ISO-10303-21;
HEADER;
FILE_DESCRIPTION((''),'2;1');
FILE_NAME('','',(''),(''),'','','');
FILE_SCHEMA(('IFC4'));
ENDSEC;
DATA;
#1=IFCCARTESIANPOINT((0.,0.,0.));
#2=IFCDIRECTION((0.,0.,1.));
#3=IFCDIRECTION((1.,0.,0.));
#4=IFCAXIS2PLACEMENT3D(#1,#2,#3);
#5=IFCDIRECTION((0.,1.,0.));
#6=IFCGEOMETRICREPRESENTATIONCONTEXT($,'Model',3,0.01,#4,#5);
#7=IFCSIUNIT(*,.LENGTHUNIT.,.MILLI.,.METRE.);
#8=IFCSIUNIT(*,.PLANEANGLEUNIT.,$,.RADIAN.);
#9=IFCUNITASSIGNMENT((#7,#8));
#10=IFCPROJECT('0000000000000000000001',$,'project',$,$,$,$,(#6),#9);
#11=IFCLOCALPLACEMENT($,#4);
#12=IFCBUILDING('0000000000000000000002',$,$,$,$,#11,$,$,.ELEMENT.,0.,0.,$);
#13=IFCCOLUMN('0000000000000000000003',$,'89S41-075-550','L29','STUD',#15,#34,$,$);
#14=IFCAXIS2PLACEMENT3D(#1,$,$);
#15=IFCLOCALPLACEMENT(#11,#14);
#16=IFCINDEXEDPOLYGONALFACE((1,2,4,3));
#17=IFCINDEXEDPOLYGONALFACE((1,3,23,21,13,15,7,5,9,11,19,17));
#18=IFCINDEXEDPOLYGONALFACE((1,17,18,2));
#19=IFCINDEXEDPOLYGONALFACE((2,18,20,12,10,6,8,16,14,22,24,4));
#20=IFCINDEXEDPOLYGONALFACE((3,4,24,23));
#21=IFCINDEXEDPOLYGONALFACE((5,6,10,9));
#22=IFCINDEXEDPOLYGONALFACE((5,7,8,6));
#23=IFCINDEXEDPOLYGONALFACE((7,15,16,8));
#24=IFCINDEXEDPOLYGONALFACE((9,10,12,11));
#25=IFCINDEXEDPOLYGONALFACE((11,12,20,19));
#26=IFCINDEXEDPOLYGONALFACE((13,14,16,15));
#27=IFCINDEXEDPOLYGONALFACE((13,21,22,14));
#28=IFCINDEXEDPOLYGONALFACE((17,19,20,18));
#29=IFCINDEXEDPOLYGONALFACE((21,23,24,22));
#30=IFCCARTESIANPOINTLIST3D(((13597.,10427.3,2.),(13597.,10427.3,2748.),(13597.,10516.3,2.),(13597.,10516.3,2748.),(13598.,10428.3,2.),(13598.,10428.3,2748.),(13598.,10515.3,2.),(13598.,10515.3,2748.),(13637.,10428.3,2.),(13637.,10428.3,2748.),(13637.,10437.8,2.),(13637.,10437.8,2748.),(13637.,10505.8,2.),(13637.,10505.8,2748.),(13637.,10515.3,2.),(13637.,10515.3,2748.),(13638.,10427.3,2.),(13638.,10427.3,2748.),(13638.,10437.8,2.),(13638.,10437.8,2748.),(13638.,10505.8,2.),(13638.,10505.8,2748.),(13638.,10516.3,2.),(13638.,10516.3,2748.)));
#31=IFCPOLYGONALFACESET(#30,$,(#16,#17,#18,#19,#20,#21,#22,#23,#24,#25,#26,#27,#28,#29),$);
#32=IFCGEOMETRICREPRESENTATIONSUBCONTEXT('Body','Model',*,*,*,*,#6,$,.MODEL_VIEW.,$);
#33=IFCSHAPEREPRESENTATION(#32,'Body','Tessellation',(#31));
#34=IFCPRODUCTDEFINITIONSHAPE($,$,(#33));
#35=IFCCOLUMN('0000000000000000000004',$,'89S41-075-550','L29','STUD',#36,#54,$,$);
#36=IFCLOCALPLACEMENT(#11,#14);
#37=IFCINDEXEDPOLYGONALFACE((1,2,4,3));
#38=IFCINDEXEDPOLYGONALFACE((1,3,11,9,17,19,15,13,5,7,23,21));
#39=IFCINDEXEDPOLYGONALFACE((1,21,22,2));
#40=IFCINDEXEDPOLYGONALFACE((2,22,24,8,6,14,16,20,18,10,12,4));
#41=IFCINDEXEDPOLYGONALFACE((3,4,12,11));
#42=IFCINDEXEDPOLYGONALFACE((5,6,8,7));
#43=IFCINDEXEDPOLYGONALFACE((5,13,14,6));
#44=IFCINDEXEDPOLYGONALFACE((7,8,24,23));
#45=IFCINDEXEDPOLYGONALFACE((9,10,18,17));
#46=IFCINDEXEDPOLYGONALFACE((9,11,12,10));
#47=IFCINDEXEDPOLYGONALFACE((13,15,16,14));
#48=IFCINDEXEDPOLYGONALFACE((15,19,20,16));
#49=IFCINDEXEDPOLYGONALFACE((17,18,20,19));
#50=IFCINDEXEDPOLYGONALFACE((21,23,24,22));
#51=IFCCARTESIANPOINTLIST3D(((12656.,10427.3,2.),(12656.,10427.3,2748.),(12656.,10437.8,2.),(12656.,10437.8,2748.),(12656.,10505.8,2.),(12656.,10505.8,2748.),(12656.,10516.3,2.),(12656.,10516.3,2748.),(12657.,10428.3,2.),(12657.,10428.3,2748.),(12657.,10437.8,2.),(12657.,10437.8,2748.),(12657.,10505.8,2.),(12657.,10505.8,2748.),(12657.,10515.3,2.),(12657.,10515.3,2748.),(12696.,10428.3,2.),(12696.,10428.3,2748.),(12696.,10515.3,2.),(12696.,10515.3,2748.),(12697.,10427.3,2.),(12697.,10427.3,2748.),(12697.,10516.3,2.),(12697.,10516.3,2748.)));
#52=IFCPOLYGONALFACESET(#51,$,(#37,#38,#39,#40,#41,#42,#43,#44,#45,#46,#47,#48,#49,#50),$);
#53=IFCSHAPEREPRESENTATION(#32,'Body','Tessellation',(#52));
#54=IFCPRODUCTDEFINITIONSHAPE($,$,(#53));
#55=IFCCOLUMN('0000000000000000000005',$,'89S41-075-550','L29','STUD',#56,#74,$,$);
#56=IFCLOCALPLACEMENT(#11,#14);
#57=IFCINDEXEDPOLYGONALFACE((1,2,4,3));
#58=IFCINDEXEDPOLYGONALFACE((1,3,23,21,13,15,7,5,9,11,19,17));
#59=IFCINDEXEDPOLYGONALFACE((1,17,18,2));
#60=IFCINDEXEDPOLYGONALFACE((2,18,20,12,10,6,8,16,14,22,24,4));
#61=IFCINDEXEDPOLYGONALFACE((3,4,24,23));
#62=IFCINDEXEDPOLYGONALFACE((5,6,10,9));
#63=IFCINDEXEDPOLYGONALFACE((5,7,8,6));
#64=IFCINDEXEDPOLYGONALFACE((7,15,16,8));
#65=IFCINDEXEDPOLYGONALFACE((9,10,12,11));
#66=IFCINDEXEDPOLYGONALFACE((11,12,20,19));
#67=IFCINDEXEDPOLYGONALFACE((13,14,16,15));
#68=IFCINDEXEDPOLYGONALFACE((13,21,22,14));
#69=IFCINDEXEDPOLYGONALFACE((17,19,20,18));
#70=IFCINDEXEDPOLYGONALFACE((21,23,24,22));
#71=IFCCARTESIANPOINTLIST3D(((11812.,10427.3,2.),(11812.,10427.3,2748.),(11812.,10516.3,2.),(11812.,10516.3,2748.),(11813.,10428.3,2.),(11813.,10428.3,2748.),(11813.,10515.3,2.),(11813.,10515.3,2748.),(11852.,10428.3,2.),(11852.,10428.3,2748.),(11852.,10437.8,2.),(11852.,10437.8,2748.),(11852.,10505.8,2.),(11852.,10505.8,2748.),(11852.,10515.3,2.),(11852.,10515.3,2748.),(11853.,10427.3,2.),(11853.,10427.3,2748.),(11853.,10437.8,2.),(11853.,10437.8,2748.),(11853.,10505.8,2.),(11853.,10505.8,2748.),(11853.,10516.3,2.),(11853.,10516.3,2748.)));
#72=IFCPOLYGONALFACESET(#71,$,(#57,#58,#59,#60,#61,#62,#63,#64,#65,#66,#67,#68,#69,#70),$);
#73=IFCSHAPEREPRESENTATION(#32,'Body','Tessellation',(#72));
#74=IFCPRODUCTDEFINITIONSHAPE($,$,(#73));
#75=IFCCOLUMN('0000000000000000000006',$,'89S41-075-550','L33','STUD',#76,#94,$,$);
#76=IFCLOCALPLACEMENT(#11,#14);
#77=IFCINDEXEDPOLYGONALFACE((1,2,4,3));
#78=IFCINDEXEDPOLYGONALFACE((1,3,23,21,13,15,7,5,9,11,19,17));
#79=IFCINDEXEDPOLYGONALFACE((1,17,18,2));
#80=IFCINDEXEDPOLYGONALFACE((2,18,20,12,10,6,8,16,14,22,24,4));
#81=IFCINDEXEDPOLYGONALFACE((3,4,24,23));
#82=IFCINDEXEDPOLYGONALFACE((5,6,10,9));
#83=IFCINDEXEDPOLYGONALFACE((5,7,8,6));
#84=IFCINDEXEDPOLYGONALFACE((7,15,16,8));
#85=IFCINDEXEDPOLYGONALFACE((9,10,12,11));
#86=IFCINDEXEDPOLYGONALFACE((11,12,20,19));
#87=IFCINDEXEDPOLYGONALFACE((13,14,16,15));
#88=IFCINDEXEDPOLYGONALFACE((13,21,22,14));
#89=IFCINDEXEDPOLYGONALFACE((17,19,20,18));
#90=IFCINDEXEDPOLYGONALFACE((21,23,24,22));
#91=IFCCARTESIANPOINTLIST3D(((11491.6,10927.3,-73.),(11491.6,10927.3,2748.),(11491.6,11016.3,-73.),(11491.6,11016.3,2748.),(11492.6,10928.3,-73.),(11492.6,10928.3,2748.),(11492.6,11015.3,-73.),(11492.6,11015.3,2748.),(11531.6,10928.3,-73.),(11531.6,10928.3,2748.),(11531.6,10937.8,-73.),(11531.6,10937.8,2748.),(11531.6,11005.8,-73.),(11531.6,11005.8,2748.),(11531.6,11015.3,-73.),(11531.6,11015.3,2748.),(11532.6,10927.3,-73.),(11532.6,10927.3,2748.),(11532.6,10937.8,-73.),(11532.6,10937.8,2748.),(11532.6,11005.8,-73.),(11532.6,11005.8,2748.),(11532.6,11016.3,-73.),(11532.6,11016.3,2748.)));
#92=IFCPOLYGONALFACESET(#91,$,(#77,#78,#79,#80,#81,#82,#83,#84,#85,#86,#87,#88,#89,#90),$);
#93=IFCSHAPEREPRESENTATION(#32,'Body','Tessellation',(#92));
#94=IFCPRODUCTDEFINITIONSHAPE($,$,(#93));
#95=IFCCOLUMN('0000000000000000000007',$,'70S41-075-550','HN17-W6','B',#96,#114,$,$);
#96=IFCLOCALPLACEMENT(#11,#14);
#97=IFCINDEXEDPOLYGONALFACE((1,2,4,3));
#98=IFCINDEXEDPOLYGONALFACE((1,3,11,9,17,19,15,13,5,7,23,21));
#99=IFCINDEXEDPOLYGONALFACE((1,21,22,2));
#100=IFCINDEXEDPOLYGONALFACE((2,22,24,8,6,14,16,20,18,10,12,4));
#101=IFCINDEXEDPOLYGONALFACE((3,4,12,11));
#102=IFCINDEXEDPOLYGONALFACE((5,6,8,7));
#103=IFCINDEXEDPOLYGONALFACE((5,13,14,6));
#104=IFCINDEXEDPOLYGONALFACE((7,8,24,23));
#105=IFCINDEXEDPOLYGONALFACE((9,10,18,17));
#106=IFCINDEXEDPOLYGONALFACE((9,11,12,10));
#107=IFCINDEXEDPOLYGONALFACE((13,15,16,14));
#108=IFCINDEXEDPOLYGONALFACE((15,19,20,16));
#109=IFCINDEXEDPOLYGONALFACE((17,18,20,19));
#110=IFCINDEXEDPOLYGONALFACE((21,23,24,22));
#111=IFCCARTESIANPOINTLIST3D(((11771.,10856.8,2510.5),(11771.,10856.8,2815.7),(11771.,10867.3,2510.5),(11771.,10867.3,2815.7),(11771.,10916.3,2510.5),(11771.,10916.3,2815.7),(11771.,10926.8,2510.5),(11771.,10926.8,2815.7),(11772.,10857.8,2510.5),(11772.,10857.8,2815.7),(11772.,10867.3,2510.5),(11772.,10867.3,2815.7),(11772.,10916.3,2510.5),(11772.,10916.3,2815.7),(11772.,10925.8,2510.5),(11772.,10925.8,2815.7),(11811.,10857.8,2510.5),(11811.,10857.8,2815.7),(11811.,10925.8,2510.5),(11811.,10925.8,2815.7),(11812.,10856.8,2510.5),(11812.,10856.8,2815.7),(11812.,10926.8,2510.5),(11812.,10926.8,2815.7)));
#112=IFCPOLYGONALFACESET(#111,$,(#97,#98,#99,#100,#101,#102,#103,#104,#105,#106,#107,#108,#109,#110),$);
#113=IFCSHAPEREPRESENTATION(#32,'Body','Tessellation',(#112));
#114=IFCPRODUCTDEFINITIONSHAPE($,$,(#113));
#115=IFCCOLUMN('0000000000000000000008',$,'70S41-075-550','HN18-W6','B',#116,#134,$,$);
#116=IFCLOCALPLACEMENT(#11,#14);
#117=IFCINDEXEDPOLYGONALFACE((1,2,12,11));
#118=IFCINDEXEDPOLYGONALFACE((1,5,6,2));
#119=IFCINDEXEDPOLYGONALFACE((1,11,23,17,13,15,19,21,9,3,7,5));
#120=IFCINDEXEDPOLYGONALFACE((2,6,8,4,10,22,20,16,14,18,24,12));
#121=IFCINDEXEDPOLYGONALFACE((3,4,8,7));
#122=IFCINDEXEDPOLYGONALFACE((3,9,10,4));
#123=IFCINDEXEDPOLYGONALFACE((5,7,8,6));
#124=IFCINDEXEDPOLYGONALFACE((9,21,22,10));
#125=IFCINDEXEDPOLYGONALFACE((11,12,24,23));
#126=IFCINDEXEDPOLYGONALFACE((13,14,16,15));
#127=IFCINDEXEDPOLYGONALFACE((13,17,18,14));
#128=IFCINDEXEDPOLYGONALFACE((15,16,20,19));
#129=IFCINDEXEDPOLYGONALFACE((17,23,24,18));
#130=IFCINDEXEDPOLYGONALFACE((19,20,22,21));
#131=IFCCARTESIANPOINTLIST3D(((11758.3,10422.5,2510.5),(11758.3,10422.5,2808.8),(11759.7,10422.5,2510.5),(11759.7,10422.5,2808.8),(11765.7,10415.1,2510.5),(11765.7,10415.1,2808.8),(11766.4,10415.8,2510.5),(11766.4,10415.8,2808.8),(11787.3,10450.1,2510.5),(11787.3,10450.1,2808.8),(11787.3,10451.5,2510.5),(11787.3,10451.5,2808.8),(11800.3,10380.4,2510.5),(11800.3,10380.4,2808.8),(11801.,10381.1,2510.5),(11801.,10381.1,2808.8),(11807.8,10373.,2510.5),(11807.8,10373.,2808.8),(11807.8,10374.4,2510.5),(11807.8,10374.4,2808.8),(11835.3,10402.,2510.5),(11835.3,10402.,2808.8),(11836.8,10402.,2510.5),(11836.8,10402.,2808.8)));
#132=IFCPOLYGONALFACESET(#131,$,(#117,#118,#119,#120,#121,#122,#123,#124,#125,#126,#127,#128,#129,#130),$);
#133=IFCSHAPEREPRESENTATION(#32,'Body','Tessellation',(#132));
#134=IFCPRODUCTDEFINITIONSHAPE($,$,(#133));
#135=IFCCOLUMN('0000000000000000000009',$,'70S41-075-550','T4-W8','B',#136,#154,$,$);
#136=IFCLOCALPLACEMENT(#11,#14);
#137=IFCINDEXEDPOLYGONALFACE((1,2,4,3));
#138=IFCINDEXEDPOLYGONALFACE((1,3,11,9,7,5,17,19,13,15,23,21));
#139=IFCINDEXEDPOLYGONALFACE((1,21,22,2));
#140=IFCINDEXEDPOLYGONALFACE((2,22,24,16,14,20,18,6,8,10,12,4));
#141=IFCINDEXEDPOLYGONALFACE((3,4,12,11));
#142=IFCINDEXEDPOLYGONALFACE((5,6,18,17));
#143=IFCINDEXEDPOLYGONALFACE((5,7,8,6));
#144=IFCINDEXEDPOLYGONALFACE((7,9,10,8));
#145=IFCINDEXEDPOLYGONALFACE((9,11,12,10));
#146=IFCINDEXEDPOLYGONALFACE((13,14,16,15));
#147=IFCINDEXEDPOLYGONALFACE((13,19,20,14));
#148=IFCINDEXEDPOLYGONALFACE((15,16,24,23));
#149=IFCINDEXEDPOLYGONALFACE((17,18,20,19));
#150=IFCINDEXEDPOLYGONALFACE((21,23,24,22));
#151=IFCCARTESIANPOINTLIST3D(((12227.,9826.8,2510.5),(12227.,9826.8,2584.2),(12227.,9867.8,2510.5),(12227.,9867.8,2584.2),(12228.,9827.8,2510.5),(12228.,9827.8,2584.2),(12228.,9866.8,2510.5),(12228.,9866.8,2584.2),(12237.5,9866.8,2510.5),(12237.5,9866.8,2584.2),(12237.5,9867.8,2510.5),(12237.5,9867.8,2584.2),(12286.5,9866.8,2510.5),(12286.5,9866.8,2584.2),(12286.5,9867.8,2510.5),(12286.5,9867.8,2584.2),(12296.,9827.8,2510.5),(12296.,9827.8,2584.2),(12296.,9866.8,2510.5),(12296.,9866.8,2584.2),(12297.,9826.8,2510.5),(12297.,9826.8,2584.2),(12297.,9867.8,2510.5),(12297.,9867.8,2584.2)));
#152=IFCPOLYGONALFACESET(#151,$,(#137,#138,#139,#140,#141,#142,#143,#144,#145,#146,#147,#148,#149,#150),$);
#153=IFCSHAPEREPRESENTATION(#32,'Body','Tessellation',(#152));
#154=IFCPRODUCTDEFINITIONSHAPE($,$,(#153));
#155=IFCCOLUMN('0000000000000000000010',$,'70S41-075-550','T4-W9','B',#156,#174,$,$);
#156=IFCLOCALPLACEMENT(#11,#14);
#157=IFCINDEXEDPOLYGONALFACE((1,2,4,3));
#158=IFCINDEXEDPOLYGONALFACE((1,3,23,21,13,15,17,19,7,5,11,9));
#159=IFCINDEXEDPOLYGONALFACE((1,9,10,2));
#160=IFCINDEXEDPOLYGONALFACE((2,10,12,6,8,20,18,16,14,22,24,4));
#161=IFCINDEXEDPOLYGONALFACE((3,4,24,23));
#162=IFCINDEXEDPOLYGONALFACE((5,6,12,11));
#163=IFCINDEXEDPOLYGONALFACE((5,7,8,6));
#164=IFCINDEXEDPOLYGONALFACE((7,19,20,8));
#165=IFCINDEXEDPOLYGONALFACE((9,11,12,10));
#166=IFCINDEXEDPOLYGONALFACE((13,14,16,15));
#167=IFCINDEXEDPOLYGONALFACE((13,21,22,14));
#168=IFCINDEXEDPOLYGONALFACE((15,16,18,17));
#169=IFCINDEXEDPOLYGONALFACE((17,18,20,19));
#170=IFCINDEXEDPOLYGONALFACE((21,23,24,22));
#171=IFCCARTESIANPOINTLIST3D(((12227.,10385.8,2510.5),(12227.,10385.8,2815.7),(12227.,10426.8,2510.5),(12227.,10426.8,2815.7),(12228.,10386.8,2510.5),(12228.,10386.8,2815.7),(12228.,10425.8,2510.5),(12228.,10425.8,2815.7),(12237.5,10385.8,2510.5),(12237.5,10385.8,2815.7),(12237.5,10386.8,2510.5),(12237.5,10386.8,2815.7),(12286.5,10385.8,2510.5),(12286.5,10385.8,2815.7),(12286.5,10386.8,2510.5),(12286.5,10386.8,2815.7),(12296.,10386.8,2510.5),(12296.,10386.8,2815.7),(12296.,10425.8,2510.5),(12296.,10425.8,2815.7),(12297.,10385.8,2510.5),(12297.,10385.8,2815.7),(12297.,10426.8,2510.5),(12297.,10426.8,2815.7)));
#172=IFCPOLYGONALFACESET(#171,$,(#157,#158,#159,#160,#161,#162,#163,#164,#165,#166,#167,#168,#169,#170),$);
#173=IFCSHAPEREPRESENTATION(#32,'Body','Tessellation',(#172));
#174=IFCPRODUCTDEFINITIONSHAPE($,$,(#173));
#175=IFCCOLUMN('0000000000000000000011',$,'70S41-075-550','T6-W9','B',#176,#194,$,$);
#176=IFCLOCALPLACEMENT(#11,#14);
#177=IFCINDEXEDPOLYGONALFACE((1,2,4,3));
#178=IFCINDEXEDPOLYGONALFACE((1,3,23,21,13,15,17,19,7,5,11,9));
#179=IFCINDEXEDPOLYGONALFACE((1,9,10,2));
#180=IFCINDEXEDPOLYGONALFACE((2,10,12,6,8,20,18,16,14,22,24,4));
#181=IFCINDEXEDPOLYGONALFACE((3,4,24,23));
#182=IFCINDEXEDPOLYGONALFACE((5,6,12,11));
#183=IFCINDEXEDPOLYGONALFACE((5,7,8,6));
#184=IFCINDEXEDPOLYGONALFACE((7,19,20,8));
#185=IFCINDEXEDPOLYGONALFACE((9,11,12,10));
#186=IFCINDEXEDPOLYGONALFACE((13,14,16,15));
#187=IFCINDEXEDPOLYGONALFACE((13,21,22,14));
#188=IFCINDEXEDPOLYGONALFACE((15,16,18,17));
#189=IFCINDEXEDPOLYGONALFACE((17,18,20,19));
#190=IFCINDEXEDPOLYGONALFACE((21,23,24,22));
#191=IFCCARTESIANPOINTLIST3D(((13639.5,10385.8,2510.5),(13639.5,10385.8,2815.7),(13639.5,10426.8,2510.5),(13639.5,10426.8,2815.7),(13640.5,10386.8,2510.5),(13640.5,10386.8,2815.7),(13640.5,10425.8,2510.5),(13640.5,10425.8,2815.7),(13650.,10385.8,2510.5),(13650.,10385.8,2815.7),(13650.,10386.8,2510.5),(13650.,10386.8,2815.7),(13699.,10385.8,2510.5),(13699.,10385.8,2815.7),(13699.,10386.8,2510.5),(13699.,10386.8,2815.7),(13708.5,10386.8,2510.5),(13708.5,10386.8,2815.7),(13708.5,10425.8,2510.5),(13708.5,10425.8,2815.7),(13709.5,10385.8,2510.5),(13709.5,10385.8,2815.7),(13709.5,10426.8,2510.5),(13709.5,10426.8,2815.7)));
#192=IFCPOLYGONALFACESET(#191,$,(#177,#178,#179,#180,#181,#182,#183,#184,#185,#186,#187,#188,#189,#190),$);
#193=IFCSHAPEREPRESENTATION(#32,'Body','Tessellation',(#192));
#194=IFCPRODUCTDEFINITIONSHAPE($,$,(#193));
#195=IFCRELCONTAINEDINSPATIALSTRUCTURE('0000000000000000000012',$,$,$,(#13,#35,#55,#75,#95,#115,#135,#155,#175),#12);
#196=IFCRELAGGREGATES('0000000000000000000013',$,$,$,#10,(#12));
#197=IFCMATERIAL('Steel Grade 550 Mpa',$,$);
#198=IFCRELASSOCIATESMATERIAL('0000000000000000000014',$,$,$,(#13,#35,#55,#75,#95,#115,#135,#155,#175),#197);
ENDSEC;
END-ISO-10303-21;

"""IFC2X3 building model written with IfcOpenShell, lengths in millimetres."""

from ifc_helpers import new_model, si_unit, direction, frame, origin, origin_with_axes, origin_2d_with_axis, place, context, subcontext, project, spatial, c_section, extrude, source, transform, mapped, material, element, save


model = new_model("IFC2X3")

# Units and contexts
model_context = context("Model", 3, precision=0.01, world=origin_with_axes(), true_north=direction((0.0, 1.0, 0.0)))
body_context = subcontext(model_context, "Body", "Model", "MODEL_VIEW")
ifc_project = project(units=[si_unit("LENGTHUNIT", "METRE", prefix="MILLI"), si_unit("PLANEANGLEUNIT", "RADIAN")], contexts=[model_context])

# Building
building_placement = place(None, origin_with_axes())
building = spatial("IfcBuilding", under=ifc_project, at=building_placement, CompositionType="ELEMENT", ElevationOfRefHeight=0.0, ElevationOfTerrain=0.0)

# Columns
ifc_material = material(Name="Steel Grade 550 Mpa")
shared_shape_1 = source(origin(), body_context, "Body", "SweptSolid", [
    extrude(c_section(Depth=89.0, Width=41.0, WallThickness=1.0, Girth=10.5, at=origin_2d_with_axis()), origin_with_axes(), (0.0, 0.0, 1.0), 2746.0),
])
column_1_placement = place(None, frame((13617.5, 10471.8, 2.0), z_axis=(0.0, 0.0, 1.0), x_axis=(1.0, 0.0, 0.0)))
element("IfcColumn", 1, at=column_1_placement, inside=building, material=ifc_material, Name="89S41-075-550", Description="L29", ObjectType="STUD", context=body_context, shape_type="MappedRepresentation", body=[
    mapped(shared_shape_1, transform((0.0, 0.0, 0.0), scale=1.0)),
])
shared_shape_2 = source(origin(), body_context, "Body", "SweptSolid", [
    extrude(c_section(Depth=89.0, Width=41.0, WallThickness=1.0, Girth=10.5, at=origin_2d_with_axis()), origin_with_axes(), (0.0, 0.0, 1.0), 2746.0),
])
column_2_placement = place(None, frame((12676.5, 10471.8, 2.0), z_axis=(0.0, 0.0, 1.0), x_axis=(-1.0, 0.0, 0.0)))
element("IfcColumn", 2, at=column_2_placement, inside=building, material=ifc_material, Name="89S41-075-550", Description="L29", ObjectType="STUD", context=body_context, shape_type="MappedRepresentation", body=[
    mapped(shared_shape_2, transform((0.0, 0.0, 0.0), scale=1.0)),
])
shared_shape_3 = source(origin(), body_context, "Body", "SweptSolid", [
    extrude(c_section(Depth=89.0, Width=41.0, WallThickness=1.0, Girth=10.5, at=origin_2d_with_axis()), origin_with_axes(), (0.0, 0.0, 1.0), 2746.0),
])
column_3_placement = place(None, frame((11832.5, 10471.8, 2.0), z_axis=(0.0, 0.0, 1.0), x_axis=(1.0, 0.0, 0.0)))
element("IfcColumn", 3, at=column_3_placement, inside=building, material=ifc_material, Name="89S41-075-550", Description="L29", ObjectType="STUD", context=body_context, shape_type="MappedRepresentation", body=[
    mapped(shared_shape_3, transform((0.0, 0.0, 0.0), scale=1.0)),
])
shared_shape_4 = source(origin(), body_context, "Body", "SweptSolid", [
    extrude(c_section(Depth=89.0, Width=41.0, WallThickness=1.0, Girth=10.5, at=origin_2d_with_axis()), origin_with_axes(), (0.0, 0.0, 1.0), 2821.0),
])
column_4_placement = place(None, frame((11512.1, 10971.8, -73.0), z_axis=(0.0, 0.0, 1.0), x_axis=(1.0, 0.0, 0.0)))
element("IfcColumn", 4, at=column_4_placement, inside=building, material=ifc_material, Name="89S41-075-550", Description="L33", ObjectType="STUD", context=body_context, shape_type="MappedRepresentation", body=[
    mapped(shared_shape_4, transform((0.0, 0.0, 0.0), scale=1.0)),
])
shared_shape_5 = source(origin(), body_context, "Body", "SweptSolid", [
    extrude(c_section(Depth=70.0, Width=41.0, WallThickness=1.0, Girth=10.5, at=origin_2d_with_axis()), origin_with_axes(), (0.0, 0.0, 1.0), 305.2),
])
column_5_placement = place(None, frame((11791.5, 10891.8, 2510.5), z_axis=(0.0, 0.0, 1.0), x_axis=(-1.0, -0.000004, 0.0)))
element("IfcColumn", 5, at=column_5_placement, inside=building, material=ifc_material, Name="70S41-075-550", Description="HN17-W6", ObjectType="B", context=body_context, shape_type="MappedRepresentation", body=[
    mapped(shared_shape_5, transform((0.0, 0.0, 0.0), scale=1.0)),
])
shared_shape_6 = source(origin(), body_context, "Body", "SweptSolid", [
    extrude(c_section(Depth=70.0, Width=41.0, WallThickness=1.0, Girth=10.5, at=origin_2d_with_axis()), origin_with_axes(), (0.0, 0.0, 1.0), 298.3),
])
column_6_placement = place(None, frame((11797.5, 10412.3, 2510.5), z_axis=(0.0, 0.0, 1.0), x_axis=(-0.707107, -0.707107, 0.0)))
element("IfcColumn", 6, at=column_6_placement, inside=building, material=ifc_material, Name="70S41-075-550", Description="HN18-W6", ObjectType="B", context=body_context, shape_type="MappedRepresentation", body=[
    mapped(shared_shape_6, transform((0.0, 0.0, 0.0), scale=1.0)),
])
shared_shape_7 = source(origin(), body_context, "Body", "SweptSolid", [
    extrude(c_section(Depth=70.0, Width=41.0, WallThickness=1.0, Girth=10.5, at=origin_2d_with_axis()), origin_with_axes(), (0.0, 0.0, 1.0), 73.7),
])
column_7_placement = place(None, frame((12262.0, 9847.3, 2584.2), z_axis=(0.0, 0.0, -1.0), x_axis=(0.0, 1.0, 0.0)))
element("IfcColumn", 7, at=column_7_placement, inside=building, material=ifc_material, Name="70S41-075-550", Description="T4-W8", ObjectType="B", context=body_context, shape_type="MappedRepresentation", body=[
    mapped(shared_shape_7, transform((0.0, 0.0, 0.0), scale=1.0)),
])
shared_shape_8 = source(origin(), body_context, "Body", "SweptSolid", [
    extrude(c_section(Depth=70.0, Width=41.0, WallThickness=1.0, Girth=10.5, at=origin_2d_with_axis()), origin_with_axes(), (0.0, 0.0, 1.0), 305.2),
])
column_8_placement = place(None, frame((12262.0, 10406.3, 2510.5), z_axis=(0.0, 0.0, 1.0), x_axis=(0.0, -1.0, 0.0)))
element("IfcColumn", 8, at=column_8_placement, inside=building, material=ifc_material, Name="70S41-075-550", Description="T4-W9", ObjectType="B", context=body_context, shape_type="MappedRepresentation", body=[
    mapped(shared_shape_8, transform((0.0, 0.0, 0.0), scale=1.0)),
])
shared_shape_9 = source(origin(), body_context, "Body", "SweptSolid", [
    extrude(c_section(Depth=70.0, Width=41.0, WallThickness=1.0, Girth=10.5, at=origin_2d_with_axis()), origin_with_axes(), (0.0, 0.0, 1.0), 305.2),
])
column_9_placement = place(None, frame((13674.5, 10406.3, 2510.5), z_axis=(0.0, 0.0, 1.0), x_axis=(0.000004, -1.0, 0.0)))
element("IfcColumn", 9, at=column_9_placement, inside=building, material=ifc_material, Name="70S41-075-550", Description="T6-W9", ObjectType="B", context=body_context, shape_type="MappedRepresentation", body=[
    mapped(shared_shape_9, transform((0.0, 0.0, 0.0), scale=1.0)),
])

save(model, "model.ifc")
